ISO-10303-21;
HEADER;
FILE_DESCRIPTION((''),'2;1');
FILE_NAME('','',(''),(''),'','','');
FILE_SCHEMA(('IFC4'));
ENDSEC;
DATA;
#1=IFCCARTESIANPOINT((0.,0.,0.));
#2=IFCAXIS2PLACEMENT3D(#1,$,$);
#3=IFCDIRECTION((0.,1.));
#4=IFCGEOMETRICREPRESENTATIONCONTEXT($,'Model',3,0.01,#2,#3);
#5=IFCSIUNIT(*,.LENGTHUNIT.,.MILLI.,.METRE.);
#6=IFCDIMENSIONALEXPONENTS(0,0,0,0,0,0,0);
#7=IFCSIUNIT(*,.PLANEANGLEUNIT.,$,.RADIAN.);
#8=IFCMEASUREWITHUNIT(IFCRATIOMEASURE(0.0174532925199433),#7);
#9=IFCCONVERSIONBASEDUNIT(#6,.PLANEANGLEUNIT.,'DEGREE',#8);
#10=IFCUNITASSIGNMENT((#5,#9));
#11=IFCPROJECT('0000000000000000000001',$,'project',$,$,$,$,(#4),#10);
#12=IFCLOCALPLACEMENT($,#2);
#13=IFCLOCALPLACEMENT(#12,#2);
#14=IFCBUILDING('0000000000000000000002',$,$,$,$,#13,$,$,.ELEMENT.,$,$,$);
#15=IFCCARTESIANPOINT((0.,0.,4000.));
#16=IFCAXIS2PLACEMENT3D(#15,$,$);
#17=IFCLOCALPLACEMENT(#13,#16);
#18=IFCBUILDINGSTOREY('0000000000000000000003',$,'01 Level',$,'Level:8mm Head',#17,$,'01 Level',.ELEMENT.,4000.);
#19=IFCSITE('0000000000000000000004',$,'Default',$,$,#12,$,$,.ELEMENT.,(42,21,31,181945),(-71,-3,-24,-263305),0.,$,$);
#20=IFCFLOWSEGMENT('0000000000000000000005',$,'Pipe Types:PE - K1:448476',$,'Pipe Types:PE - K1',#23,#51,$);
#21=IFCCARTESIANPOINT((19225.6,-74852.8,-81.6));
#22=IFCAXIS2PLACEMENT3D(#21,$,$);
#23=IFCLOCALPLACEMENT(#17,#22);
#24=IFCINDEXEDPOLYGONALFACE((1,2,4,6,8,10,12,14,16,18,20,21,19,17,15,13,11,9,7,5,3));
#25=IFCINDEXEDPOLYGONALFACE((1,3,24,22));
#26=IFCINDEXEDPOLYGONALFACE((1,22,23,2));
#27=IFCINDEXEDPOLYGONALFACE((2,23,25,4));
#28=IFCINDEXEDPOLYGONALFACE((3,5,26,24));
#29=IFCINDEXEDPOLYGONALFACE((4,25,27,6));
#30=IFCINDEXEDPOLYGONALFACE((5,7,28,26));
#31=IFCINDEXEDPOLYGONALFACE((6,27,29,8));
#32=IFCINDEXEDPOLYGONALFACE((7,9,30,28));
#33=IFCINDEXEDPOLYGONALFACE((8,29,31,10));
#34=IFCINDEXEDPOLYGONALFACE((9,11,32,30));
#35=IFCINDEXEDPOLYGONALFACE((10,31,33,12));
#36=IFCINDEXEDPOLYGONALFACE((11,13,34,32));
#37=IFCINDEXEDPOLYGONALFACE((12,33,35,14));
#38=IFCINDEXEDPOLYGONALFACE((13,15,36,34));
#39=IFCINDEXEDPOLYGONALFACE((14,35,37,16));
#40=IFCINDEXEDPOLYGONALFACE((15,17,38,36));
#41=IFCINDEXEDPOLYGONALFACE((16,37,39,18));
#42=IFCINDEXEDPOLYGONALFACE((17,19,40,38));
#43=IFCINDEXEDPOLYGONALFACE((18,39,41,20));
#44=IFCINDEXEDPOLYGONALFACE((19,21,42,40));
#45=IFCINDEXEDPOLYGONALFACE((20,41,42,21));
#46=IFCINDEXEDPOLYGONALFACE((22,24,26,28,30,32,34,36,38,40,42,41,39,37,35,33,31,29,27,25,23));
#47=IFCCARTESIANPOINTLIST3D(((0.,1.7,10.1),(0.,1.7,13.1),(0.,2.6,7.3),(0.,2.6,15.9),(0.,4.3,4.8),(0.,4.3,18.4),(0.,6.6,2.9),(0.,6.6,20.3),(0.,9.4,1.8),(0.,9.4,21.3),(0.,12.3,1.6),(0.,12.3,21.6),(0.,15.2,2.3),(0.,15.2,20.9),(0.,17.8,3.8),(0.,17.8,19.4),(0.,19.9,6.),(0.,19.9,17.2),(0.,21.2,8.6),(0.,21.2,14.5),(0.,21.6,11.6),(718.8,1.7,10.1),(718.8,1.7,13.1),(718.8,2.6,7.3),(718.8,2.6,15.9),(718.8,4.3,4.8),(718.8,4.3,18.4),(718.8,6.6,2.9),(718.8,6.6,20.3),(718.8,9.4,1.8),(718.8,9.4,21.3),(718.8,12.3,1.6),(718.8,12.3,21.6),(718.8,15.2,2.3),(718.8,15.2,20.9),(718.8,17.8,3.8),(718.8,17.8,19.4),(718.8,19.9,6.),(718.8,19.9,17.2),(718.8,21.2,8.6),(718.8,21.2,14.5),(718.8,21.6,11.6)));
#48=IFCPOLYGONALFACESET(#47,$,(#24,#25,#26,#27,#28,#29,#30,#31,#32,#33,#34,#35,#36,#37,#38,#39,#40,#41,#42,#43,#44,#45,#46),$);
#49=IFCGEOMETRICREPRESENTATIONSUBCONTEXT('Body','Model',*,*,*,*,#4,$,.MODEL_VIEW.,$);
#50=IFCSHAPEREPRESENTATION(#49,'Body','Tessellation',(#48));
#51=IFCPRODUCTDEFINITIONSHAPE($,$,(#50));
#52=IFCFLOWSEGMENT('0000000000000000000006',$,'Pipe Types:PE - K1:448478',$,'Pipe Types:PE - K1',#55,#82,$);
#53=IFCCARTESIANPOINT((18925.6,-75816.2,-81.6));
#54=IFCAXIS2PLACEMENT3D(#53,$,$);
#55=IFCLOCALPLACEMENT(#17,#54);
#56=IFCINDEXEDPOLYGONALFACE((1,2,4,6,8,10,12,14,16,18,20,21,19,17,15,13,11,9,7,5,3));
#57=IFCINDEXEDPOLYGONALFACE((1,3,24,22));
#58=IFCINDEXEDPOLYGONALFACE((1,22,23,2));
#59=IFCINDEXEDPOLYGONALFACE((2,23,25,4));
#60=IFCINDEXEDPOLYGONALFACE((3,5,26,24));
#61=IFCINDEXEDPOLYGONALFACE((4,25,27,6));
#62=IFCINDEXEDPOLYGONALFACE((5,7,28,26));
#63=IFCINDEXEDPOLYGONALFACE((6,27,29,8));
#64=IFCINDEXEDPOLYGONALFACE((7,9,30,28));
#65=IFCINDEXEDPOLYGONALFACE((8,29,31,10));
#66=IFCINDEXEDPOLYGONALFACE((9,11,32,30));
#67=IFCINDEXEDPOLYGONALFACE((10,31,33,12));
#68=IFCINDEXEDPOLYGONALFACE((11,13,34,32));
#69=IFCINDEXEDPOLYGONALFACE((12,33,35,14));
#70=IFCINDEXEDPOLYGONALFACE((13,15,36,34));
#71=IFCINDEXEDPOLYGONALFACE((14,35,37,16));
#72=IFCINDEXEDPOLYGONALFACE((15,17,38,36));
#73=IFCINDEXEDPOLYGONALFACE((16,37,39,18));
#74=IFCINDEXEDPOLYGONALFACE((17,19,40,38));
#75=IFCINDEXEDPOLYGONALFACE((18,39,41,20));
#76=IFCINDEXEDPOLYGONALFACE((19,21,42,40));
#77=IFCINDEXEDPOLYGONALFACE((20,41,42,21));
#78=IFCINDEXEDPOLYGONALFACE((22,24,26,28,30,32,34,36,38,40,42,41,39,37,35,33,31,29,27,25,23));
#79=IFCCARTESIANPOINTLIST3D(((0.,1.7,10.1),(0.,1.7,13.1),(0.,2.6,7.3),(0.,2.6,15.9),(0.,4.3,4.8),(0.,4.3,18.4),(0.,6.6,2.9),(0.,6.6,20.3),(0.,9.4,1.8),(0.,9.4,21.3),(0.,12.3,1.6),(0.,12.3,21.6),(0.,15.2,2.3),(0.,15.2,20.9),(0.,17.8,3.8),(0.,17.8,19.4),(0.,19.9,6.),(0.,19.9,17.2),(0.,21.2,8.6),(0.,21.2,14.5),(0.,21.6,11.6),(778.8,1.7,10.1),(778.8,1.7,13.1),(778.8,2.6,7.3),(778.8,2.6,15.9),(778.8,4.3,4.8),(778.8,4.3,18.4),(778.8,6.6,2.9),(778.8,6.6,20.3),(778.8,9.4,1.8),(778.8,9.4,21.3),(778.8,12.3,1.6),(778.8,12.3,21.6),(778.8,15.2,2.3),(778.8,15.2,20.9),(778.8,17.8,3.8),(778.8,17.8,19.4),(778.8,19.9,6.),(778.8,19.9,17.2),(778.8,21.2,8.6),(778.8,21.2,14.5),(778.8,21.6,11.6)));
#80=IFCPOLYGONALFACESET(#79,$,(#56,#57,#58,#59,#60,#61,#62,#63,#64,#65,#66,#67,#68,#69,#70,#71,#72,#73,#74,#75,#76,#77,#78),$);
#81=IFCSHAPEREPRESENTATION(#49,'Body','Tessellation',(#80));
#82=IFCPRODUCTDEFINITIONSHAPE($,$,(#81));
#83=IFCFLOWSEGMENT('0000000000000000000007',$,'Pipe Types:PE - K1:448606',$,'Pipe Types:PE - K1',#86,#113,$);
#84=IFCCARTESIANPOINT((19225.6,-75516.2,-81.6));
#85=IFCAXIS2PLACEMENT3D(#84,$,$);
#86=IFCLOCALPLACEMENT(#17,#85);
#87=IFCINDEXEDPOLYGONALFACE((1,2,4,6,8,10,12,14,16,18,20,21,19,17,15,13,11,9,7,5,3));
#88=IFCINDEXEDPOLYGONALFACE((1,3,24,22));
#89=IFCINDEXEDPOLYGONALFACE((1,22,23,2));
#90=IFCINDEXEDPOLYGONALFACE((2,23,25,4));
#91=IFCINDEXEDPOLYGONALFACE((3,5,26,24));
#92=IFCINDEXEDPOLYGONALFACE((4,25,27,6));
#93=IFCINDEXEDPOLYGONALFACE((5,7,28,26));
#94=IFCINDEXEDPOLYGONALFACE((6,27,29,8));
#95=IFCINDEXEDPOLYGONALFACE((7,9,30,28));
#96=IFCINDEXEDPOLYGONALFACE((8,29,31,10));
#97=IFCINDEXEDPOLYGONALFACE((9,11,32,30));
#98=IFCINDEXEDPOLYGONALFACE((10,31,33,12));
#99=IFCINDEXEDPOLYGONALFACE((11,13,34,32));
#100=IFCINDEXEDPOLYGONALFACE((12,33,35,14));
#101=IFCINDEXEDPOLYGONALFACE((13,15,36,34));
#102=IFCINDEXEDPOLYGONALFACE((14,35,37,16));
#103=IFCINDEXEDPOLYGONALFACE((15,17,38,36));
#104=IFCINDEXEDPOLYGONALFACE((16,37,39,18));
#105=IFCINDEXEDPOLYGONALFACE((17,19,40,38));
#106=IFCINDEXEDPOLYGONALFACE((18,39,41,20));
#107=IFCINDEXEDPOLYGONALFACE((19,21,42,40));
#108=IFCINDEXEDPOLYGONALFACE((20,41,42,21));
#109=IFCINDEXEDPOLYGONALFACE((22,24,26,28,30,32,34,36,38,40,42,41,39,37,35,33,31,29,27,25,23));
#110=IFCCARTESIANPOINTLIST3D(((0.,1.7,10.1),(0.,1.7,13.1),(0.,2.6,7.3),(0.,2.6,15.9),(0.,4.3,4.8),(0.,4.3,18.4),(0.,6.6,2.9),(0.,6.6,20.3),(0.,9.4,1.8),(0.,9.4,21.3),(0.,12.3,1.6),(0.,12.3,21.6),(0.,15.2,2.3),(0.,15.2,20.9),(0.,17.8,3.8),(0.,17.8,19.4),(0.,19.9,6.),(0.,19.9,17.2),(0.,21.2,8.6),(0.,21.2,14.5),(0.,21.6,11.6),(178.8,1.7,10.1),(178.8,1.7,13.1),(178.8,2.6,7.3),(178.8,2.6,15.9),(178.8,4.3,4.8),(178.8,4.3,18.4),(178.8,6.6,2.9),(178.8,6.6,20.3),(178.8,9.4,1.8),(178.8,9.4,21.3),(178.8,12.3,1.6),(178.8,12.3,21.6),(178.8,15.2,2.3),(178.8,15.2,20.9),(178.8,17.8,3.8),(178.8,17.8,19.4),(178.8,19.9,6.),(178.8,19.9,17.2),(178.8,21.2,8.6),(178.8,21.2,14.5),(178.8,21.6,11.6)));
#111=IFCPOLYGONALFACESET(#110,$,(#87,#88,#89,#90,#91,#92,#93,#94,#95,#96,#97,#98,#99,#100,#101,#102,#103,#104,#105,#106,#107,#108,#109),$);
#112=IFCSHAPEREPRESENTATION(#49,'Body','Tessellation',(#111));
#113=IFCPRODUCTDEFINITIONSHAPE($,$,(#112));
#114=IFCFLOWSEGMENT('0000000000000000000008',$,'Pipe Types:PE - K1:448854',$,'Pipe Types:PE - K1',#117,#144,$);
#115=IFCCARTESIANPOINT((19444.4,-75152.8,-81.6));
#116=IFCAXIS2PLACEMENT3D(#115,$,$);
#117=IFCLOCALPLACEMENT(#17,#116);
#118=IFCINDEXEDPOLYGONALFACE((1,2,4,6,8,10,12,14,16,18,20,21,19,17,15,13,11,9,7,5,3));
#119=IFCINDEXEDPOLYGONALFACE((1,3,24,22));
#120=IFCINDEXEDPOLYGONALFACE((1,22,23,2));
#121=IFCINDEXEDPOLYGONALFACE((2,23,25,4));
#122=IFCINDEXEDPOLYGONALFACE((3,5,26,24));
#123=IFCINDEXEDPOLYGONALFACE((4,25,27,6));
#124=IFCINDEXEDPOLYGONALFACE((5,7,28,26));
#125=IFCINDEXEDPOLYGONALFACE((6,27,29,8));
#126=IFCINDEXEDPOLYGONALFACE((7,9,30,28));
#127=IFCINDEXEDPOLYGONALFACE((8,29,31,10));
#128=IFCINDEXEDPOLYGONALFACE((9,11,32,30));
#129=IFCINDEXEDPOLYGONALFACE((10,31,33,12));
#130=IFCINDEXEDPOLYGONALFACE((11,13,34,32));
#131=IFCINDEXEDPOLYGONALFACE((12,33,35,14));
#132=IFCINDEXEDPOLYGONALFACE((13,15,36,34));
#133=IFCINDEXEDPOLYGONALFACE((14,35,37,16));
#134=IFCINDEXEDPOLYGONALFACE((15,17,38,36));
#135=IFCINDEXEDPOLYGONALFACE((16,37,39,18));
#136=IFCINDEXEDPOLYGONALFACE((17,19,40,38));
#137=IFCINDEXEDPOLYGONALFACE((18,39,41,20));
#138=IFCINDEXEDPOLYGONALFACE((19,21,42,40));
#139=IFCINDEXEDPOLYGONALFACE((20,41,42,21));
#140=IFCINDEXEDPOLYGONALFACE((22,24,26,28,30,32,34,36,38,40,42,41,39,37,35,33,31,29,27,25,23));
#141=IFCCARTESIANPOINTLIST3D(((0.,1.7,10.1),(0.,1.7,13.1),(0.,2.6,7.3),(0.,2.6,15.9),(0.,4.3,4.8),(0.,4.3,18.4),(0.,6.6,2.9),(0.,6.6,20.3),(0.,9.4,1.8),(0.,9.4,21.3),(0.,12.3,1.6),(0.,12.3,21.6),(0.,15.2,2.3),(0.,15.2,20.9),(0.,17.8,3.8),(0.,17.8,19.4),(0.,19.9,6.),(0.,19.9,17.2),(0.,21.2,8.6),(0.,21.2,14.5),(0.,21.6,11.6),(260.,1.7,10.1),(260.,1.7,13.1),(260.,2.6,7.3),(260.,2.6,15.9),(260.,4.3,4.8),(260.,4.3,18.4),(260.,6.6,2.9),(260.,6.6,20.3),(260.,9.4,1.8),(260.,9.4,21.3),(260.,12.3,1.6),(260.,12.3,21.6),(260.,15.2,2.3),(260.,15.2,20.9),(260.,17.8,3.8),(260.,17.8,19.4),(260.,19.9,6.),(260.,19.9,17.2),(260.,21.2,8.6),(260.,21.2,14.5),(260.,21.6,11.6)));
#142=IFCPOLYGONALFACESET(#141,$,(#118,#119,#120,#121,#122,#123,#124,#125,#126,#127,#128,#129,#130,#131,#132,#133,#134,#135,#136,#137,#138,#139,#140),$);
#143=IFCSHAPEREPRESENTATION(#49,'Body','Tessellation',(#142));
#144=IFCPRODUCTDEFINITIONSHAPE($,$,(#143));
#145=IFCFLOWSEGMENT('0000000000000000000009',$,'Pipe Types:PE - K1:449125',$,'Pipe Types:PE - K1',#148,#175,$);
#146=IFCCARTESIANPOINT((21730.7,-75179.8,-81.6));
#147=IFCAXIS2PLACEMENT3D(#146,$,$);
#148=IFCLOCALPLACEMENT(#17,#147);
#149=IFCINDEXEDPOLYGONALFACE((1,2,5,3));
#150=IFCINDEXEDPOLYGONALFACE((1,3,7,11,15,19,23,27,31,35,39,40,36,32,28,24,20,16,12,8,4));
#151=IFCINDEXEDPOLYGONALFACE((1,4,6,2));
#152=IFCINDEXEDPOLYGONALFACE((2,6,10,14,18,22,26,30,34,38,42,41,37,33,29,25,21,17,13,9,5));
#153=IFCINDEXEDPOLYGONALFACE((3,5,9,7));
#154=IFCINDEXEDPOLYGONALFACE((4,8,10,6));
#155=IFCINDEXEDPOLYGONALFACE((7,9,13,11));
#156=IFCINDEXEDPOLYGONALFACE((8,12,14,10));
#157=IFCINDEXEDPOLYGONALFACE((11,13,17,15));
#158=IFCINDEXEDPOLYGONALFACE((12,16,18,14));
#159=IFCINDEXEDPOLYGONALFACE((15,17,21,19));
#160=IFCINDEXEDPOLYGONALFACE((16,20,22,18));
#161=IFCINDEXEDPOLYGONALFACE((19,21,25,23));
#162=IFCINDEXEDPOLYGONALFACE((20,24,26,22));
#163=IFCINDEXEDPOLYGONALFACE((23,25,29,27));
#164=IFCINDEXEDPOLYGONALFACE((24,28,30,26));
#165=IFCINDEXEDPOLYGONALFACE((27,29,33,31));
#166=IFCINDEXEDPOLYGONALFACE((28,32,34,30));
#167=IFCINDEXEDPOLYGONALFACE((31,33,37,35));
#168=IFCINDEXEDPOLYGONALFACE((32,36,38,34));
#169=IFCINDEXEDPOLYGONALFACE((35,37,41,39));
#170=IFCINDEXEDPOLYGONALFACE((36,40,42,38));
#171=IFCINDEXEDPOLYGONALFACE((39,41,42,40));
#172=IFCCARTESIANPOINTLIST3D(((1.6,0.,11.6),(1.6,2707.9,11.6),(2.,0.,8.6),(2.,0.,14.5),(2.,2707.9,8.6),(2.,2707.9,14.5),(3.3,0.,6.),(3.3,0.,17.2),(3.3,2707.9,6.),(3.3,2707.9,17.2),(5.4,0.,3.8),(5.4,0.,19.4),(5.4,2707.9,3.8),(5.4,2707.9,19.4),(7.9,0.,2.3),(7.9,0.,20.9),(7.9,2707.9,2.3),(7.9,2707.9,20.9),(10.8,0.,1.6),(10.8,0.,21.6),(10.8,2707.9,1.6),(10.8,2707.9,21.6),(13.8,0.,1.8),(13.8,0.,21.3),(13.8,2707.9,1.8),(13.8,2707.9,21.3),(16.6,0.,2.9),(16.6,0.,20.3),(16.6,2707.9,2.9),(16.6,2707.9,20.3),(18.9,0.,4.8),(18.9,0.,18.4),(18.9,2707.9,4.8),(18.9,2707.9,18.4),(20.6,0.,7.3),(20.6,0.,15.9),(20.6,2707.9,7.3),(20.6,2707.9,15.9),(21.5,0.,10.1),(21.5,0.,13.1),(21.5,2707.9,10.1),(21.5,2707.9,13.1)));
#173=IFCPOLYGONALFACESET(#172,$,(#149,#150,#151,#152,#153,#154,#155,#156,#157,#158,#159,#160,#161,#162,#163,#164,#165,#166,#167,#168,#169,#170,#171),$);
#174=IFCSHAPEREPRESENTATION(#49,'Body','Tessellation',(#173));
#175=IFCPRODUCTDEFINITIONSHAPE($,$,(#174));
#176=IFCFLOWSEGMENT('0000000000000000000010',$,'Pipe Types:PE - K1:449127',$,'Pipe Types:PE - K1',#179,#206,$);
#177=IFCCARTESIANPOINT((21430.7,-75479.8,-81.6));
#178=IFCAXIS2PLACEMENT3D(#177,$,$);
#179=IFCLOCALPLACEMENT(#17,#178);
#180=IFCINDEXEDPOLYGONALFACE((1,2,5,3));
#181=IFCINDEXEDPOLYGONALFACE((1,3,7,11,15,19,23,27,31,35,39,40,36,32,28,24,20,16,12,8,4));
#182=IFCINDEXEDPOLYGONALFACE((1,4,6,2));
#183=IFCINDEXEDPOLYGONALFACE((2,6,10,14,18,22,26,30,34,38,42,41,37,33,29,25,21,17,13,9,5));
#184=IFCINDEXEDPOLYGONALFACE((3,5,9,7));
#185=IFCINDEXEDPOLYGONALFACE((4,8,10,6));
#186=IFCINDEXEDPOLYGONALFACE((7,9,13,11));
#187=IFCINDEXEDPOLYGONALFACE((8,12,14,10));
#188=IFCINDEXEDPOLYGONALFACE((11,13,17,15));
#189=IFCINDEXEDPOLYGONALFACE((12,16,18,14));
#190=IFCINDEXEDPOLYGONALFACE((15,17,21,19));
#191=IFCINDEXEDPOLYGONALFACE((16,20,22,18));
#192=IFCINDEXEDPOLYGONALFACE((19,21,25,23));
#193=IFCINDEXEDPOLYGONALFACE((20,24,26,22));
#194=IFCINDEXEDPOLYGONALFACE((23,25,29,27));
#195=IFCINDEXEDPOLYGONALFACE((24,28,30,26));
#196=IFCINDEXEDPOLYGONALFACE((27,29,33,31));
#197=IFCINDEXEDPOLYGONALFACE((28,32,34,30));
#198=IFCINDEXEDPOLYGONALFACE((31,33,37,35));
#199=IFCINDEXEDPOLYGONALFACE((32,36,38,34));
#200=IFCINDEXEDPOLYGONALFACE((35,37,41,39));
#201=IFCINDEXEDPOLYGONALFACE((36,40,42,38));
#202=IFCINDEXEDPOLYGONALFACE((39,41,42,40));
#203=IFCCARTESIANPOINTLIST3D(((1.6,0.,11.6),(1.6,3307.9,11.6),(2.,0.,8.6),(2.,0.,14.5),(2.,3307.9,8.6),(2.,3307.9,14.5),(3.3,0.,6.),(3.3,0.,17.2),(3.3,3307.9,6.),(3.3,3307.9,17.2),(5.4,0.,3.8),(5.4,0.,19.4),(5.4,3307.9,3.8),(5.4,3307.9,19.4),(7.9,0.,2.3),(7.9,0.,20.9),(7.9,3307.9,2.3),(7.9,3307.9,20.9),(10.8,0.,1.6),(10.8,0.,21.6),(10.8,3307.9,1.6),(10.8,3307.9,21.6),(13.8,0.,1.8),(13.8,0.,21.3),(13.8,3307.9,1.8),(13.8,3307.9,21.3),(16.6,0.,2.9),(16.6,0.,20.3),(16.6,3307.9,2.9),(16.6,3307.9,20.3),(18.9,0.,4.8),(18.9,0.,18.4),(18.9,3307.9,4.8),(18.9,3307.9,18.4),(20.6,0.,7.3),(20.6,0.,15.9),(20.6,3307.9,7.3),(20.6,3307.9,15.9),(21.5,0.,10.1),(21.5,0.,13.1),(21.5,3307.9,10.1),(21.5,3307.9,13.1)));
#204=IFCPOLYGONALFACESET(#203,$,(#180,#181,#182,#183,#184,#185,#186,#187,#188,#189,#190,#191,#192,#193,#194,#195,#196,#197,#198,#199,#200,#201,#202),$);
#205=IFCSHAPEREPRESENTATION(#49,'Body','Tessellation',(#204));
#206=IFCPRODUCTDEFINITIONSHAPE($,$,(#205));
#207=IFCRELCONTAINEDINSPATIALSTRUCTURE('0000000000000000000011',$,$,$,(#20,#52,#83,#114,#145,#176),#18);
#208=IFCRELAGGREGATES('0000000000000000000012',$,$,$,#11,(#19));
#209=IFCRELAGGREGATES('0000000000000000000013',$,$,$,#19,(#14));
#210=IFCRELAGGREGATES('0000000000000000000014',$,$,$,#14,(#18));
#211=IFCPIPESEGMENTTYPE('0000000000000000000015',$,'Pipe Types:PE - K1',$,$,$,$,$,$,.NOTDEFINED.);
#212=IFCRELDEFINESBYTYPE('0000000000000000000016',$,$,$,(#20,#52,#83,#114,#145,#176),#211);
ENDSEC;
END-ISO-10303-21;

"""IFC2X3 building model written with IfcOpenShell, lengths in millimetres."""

from ifc_helpers import new_model, entity, si_unit, converted_unit, direction, frame, frame_2d, origin, origin_2d_with_axis, place, context, subcontext, project, spatial, circle, extrude, type_object, element, save


model = new_model("IFC2X3")

# Units and contexts
model_context = context("Model", 3, precision=0.01, world=origin(), true_north=direction((0.0, 1.0)))
body_context = subcontext(model_context, "Body", "Model", "MODEL_VIEW")
ifc_project = project(units=[si_unit("LENGTHUNIT", "METRE", prefix="MILLI"), converted_unit("PLANEANGLEUNIT", "DEGREE", entity("IfcRatioMeasure", 0.0174532925199433), si_unit("PLANEANGLEUNIT", "RADIAN"), dimensions=[0, 0, 0, 0, 0, 0, 0])], contexts=[model_context])

# Site, building, storey
site_placement = place(None, origin())
site = spatial("IfcSite", under=ifc_project, at=site_placement, Name="Default", CompositionType="ELEMENT", RefLatitude=(42, 21, 31, 181945), RefLongitude=(-71, -3, -24, -263305), RefElevation=0.0)
building_placement = place(site_placement, origin())
building = spatial("IfcBuilding", under=site, at=building_placement, CompositionType="ELEMENT")
storey_placement = place(building_placement, frame((0.0, 0.0, 4000.0)))
storey = spatial("IfcBuildingStorey", under=building, at=storey_placement, Name="01 Level", ObjectType="Level:8mm Head", LongName="01 Level", CompositionType="ELEMENT", Elevation=4000.0)

# Flow segments
pipe_segment_type = type_object("IfcPipeSegmentType", Name="Pipe Types:PE - K1", PredefinedType="NOTDEFINED")
flow_segment_1_placement = place(storey_placement, frame((19225.6, -74852.8, -81.6)))
element("IfcFlowSegment", 1, at=flow_segment_1_placement, inside=storey, type_object=pipe_segment_type, Name="Pipe Types:PE - K1:448476", ObjectType="Pipe Types:PE - K1", context=body_context, shape_type="SweptSolid", body=[
    extrude(circle(Radius=10.0, at=frame_2d((0.0, 0.0), x_axis=(1.0, 0.0))), frame((0.0, 11.6, 11.6), z_axis=(1.0, 0.0, 0.0), x_axis=(0.0, 1.0, 0.0)), (0.0, 0.0, 1.0), 718.8),
])
flow_segment_2_placement = place(storey_placement, frame((18925.6, -75816.2, -81.6)))
element("IfcFlowSegment", 2, at=flow_segment_2_placement, inside=storey, type_object=pipe_segment_type, Name="Pipe Types:PE - K1:448478", ObjectType="Pipe Types:PE - K1", context=body_context, shape_type="SweptSolid", body=[
    extrude(circle(Radius=10.0, at=frame_2d((0.0, 0.0), x_axis=(1.0, 0.0))), frame((0.0, 11.6, 11.6), z_axis=(1.0, 0.0, 0.0), x_axis=(0.0, 1.0, 0.0)), (0.0, 0.0, 1.0), 778.8),
])
flow_segment_3_placement = place(storey_placement, frame((19225.6, -75516.2, -81.6)))
element("IfcFlowSegment", 3, at=flow_segment_3_placement, inside=storey, type_object=pipe_segment_type, Name="Pipe Types:PE - K1:448606", ObjectType="Pipe Types:PE - K1", context=body_context, shape_type="SweptSolid", body=[
    extrude(circle(Radius=10.0, at=origin_2d_with_axis()), frame((0.0, 11.6, 11.6), z_axis=(1.0, 0.0, 0.0), x_axis=(0.0, 1.0, 0.0)), (0.0, 0.0, 1.0), 178.8),
])
flow_segment_4_placement = place(storey_placement, frame((19444.4, -75152.8, -81.6)))
element("IfcFlowSegment", 4, at=flow_segment_4_placement, inside=storey, type_object=pipe_segment_type, Name="Pipe Types:PE - K1:448854", ObjectType="Pipe Types:PE - K1", context=body_context, shape_type="SweptSolid", body=[
    extrude(circle(Radius=10.0, at=frame_2d((0.0, 0.0), x_axis=(1.0, 0.0))), frame((0.0, 11.6, 11.6), z_axis=(1.0, 0.0, 0.0), x_axis=(0.0, 1.0, 0.0)), (0.0, 0.0, 1.0), 260.0),
])
flow_segment_5_placement = place(storey_placement, frame((21730.7, -75179.8, -81.6)))
element("IfcFlowSegment", 5, at=flow_segment_5_placement, inside=storey, type_object=pipe_segment_type, Name="Pipe Types:PE - K1:449125", ObjectType="Pipe Types:PE - K1", context=body_context, shape_type="SweptSolid", body=[
    extrude(circle(Radius=10.0, at=frame_2d((0.0, 0.0), x_axis=(1.0, 0.0))), frame((11.6, 0.0, 11.6), z_axis=(0.0, 1.0, 0.0), x_axis=(-1.0, 0.0, 0.0)), (0.0, 0.0, 1.0), 2707.9),
])
flow_segment_6_placement = place(storey_placement, frame((21430.7, -75479.8, -81.6)))
element("IfcFlowSegment", 6, at=flow_segment_6_placement, inside=storey, type_object=pipe_segment_type, Name="Pipe Types:PE - K1:449127", ObjectType="Pipe Types:PE - K1", context=body_context, shape_type="SweptSolid", body=[
    extrude(circle(Radius=10.0, at=frame_2d((0.0, 0.0), x_axis=(1.0, 0.0))), frame((11.6, 0.0, 11.6), z_axis=(0.0, 1.0, 0.0), x_axis=(-1.0, 0.0, 0.0)), (0.0, 0.0, 1.0), 3307.9),
])

save(model, "model.ifc")
